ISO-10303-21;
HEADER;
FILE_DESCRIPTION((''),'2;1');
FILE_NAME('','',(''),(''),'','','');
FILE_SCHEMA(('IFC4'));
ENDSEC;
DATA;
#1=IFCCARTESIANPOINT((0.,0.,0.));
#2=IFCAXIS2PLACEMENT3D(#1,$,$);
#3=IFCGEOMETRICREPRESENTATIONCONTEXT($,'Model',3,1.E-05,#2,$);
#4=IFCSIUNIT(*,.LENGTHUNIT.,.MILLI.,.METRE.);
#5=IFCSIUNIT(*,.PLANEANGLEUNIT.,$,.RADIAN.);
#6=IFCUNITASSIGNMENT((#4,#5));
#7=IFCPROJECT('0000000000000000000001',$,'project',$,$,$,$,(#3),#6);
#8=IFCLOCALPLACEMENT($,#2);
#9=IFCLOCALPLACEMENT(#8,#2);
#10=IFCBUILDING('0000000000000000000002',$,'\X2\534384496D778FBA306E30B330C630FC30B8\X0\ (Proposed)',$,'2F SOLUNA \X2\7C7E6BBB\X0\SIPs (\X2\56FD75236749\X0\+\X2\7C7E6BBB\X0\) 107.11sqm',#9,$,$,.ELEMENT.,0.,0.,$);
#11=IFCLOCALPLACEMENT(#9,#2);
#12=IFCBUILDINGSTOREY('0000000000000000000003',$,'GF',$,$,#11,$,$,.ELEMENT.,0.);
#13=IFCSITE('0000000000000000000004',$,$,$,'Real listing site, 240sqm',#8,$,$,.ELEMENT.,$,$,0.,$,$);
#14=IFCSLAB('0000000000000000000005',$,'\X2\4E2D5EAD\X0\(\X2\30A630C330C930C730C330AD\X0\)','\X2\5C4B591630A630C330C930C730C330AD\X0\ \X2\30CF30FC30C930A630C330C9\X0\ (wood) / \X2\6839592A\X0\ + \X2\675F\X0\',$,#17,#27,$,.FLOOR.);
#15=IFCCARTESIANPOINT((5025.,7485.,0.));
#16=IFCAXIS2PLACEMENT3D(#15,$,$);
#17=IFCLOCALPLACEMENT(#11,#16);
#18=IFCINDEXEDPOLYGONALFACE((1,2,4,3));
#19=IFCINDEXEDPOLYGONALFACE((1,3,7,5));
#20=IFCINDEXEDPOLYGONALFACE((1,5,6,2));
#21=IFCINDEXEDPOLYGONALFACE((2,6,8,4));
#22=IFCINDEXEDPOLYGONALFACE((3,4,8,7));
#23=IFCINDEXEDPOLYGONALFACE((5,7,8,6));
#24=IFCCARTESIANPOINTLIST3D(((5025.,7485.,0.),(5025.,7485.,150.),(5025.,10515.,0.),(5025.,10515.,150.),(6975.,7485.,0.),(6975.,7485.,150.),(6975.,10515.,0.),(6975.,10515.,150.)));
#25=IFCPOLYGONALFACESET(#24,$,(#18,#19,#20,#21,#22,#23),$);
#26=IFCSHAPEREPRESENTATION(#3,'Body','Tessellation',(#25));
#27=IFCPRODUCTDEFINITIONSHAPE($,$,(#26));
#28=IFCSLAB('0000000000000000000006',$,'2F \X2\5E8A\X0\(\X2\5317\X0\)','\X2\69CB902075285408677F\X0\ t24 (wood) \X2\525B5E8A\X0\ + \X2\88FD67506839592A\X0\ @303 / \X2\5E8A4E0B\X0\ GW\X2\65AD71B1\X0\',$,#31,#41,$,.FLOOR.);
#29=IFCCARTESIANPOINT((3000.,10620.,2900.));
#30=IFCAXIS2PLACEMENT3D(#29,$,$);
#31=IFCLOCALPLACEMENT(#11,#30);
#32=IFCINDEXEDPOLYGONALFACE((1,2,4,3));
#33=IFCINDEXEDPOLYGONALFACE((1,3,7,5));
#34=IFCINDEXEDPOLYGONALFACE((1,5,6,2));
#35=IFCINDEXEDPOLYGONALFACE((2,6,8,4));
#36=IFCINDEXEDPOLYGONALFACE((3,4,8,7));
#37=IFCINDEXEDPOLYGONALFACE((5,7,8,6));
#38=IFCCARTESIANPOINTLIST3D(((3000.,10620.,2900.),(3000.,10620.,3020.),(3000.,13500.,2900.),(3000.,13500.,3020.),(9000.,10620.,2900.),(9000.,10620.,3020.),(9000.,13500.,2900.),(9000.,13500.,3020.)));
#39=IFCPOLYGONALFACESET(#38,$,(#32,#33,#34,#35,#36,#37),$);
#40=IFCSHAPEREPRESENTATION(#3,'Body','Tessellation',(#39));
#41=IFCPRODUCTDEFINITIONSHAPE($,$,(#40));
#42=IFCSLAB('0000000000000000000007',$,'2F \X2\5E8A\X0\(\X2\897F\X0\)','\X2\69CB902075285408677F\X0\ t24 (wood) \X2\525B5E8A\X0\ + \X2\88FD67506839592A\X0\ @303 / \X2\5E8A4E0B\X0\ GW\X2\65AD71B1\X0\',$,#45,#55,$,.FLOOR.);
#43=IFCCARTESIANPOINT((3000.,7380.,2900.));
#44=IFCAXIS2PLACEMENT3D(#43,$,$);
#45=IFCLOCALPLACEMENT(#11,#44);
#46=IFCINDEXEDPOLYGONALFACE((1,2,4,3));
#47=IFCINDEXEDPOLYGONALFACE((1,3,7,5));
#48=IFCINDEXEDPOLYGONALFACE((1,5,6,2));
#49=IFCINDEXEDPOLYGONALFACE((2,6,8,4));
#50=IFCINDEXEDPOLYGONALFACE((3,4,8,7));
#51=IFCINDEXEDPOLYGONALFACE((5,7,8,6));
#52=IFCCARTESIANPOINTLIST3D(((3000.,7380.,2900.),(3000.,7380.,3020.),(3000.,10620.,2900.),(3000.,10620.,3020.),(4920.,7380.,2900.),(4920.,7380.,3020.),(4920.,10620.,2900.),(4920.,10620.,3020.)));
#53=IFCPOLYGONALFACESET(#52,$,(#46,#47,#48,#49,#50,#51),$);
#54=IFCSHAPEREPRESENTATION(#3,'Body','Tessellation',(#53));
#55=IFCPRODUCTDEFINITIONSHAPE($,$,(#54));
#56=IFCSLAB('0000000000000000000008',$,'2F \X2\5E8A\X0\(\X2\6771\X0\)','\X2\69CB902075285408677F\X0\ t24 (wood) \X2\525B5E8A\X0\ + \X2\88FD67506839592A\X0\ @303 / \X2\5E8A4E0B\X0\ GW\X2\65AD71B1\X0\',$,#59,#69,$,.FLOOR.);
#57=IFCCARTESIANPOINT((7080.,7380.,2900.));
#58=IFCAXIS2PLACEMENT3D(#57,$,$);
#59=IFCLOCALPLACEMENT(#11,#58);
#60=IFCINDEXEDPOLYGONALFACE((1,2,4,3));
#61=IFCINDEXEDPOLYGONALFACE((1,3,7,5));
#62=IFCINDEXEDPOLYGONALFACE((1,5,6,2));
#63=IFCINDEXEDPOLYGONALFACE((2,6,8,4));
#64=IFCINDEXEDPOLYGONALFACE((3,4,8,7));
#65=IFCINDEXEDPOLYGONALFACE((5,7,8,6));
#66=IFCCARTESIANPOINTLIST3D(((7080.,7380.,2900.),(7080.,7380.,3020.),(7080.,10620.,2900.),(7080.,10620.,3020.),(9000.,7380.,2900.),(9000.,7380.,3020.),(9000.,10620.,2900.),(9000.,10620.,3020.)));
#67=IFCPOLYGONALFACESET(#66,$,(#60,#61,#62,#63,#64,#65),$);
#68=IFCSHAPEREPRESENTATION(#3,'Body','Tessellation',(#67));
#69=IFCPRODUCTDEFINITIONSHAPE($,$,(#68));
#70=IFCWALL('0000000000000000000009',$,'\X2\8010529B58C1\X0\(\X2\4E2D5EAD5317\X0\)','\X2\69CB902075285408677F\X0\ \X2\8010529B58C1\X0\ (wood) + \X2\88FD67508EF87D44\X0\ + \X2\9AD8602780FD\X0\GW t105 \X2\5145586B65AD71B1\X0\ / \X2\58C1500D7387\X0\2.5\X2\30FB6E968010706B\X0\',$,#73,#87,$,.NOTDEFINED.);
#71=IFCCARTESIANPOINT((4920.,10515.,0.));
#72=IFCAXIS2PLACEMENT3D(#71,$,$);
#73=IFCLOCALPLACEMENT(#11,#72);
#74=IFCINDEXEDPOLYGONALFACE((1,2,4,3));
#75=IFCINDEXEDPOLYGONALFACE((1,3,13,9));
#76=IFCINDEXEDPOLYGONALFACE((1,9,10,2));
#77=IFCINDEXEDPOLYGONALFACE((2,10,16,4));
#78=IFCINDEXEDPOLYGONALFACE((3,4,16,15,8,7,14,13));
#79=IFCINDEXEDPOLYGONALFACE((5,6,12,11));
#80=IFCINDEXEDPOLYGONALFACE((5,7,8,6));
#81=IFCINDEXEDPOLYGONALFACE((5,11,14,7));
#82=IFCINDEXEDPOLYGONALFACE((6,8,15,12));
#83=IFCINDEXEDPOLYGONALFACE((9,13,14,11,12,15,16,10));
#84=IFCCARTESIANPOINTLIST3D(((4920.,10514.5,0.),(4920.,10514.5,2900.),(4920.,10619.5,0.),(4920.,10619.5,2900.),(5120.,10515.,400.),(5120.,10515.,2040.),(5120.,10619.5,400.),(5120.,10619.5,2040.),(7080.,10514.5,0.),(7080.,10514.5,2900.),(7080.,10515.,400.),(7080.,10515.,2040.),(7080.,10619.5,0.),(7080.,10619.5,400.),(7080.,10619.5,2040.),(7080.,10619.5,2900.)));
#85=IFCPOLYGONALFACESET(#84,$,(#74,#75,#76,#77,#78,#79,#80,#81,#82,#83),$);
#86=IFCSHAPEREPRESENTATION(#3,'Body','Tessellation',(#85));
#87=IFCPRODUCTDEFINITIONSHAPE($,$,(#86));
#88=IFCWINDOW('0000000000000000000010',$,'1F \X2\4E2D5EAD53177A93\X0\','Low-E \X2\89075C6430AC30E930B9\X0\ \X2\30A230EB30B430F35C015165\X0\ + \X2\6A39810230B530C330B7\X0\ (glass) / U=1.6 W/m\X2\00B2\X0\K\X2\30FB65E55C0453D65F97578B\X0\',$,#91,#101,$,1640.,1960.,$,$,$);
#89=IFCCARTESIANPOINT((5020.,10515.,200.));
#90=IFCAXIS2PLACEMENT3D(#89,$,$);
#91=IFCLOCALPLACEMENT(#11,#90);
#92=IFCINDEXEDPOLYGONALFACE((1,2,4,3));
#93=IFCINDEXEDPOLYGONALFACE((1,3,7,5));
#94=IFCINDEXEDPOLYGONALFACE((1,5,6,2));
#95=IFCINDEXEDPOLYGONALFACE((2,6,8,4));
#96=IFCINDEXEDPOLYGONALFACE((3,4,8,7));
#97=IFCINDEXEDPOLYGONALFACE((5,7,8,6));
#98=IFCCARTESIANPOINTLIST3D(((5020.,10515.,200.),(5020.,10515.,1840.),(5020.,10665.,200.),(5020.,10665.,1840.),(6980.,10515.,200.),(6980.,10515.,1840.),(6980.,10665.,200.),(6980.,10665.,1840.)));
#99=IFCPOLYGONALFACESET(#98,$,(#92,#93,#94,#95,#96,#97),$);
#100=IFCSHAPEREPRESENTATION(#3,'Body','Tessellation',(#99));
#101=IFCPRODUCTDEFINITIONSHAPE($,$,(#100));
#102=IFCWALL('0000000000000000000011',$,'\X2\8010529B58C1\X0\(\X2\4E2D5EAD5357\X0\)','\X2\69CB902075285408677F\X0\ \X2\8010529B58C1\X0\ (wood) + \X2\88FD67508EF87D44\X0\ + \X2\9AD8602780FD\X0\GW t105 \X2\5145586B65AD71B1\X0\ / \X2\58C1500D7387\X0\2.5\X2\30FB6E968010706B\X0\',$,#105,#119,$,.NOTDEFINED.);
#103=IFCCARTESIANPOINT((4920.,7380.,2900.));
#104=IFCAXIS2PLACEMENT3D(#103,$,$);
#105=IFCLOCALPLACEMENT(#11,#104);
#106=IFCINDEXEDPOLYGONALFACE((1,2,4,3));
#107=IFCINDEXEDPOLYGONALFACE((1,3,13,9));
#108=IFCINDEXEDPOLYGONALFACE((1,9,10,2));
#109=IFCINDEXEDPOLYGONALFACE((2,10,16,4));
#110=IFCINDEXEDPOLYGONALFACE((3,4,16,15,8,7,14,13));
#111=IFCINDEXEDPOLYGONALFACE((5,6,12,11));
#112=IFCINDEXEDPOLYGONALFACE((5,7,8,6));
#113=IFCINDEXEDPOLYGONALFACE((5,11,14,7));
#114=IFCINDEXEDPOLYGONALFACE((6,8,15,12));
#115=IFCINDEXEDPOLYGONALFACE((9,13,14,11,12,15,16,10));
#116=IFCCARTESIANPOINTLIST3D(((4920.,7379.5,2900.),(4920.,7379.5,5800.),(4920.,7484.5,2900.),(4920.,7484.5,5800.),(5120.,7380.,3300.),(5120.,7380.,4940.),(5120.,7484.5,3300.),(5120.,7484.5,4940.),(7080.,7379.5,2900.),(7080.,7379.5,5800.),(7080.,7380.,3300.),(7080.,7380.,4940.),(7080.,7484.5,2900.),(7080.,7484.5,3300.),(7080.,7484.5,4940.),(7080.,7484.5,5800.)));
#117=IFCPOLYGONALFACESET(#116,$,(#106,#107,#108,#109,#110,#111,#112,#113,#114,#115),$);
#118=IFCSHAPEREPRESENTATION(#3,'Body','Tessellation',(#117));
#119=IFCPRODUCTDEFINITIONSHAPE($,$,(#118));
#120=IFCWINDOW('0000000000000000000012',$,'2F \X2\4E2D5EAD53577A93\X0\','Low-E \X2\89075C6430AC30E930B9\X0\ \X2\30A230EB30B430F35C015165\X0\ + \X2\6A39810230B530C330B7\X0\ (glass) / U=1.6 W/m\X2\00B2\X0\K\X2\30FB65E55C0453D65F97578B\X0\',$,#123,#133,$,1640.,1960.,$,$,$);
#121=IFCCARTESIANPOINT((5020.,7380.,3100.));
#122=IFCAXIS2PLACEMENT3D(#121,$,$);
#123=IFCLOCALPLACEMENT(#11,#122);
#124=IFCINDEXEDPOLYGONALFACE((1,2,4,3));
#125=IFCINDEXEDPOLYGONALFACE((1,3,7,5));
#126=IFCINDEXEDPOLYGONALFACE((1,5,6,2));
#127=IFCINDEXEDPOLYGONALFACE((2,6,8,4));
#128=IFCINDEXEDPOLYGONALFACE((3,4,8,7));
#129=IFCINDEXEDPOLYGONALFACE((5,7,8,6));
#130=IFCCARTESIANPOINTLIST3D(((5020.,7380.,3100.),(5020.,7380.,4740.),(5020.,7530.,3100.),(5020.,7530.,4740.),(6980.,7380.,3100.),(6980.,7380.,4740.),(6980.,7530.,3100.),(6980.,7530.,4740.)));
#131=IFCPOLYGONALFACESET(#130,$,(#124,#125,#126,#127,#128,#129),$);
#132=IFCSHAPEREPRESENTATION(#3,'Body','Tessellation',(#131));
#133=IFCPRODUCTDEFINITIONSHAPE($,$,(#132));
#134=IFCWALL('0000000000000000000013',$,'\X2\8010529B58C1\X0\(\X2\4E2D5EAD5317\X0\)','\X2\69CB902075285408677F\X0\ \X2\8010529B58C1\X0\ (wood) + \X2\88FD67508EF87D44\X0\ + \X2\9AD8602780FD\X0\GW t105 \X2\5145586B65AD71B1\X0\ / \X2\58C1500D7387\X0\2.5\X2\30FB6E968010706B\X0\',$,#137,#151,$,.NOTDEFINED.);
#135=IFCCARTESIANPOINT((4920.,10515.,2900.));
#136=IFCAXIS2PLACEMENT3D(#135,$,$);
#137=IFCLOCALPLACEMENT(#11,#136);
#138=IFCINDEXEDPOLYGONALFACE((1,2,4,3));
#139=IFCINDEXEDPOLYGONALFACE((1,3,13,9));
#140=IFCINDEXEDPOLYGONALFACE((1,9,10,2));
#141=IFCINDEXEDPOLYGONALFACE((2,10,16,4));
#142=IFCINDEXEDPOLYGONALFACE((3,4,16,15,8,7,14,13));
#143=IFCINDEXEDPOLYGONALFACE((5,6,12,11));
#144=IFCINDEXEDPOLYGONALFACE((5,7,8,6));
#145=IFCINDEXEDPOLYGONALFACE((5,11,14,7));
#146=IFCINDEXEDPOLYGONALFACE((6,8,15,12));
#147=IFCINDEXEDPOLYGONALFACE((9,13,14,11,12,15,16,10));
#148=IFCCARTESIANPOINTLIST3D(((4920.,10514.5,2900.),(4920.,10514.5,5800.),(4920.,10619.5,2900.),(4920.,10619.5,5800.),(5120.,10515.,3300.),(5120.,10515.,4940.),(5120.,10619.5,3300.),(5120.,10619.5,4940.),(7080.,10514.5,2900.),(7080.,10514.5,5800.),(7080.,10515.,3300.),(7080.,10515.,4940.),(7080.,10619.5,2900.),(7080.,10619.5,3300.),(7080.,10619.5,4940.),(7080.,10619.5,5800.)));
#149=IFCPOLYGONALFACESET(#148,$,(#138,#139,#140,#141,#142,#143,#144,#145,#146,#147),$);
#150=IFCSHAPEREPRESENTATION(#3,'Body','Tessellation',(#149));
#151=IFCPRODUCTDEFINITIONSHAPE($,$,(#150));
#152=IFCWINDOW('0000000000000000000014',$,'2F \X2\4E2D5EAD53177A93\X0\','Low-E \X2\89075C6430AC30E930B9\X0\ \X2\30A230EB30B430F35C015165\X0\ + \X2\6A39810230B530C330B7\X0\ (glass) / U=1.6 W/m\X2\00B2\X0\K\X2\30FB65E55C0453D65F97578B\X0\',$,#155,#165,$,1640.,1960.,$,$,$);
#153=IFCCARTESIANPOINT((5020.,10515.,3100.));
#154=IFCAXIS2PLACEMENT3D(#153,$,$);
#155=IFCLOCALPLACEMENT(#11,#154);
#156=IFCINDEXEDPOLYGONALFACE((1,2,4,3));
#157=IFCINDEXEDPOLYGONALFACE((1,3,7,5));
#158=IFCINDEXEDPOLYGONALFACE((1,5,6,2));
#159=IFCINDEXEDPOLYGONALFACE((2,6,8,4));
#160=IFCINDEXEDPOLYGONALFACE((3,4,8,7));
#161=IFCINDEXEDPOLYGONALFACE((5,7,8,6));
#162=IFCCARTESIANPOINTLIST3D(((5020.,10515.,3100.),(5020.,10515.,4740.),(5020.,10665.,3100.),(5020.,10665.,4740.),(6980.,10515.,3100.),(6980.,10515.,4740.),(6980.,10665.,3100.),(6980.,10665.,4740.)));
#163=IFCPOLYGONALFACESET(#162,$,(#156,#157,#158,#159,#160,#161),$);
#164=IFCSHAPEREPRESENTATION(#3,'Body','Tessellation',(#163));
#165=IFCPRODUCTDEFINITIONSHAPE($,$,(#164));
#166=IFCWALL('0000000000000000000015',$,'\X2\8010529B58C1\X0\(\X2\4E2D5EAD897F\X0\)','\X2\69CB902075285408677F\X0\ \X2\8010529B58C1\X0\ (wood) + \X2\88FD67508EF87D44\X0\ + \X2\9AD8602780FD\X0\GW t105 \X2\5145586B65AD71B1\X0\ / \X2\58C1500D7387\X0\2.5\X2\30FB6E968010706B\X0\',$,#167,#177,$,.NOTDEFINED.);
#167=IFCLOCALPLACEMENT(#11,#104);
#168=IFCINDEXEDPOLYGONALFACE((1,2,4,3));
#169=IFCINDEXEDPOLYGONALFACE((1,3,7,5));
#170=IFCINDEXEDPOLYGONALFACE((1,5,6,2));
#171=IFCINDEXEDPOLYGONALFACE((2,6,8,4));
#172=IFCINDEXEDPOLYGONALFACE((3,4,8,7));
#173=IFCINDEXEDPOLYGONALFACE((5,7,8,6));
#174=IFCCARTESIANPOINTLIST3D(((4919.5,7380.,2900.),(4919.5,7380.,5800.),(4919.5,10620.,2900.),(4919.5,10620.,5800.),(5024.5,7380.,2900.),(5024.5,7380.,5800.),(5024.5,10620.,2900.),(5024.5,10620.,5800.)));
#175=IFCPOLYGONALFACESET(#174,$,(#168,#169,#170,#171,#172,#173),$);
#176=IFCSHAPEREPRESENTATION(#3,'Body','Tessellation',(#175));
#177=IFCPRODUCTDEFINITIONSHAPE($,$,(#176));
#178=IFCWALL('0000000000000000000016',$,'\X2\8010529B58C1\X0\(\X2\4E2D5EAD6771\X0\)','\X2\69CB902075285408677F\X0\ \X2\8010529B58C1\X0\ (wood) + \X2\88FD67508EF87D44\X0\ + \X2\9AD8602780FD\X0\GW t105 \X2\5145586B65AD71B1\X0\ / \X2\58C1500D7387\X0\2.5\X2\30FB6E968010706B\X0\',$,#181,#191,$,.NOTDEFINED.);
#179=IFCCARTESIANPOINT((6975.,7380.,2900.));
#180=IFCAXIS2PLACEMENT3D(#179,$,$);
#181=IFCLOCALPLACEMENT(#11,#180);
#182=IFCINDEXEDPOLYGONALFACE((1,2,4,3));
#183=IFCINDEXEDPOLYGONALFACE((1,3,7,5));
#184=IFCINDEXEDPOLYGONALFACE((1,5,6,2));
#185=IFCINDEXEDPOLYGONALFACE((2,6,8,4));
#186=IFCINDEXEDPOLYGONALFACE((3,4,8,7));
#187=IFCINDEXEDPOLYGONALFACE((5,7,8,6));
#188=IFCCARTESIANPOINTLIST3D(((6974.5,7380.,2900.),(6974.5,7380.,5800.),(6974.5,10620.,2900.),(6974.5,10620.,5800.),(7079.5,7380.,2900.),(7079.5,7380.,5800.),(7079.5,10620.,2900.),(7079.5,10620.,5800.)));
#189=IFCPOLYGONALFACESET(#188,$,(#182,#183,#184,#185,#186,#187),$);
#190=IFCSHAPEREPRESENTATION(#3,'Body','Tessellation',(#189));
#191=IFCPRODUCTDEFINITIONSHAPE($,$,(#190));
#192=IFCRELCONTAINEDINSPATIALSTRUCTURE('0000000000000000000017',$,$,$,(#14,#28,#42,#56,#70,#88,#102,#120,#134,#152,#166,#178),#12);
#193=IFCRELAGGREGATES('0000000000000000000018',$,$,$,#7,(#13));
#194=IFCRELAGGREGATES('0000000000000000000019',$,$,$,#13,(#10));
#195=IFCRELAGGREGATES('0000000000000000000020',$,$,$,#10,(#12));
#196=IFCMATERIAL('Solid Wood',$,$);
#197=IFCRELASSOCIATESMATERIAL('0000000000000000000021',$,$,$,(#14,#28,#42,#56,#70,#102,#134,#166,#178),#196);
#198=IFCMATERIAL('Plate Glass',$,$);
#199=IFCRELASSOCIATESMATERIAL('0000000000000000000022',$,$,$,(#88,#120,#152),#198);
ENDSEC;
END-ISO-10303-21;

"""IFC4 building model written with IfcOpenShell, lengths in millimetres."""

from ifc_helpers import new_model, si_unit, frame, frame_2d, origin, place, context, project, spatial, rectangle, extrude, material, element, fill, save


model = new_model("IFC4")

# Units and contexts
model_context = context("Model", 3, precision=1e-05, world=origin())
ifc_project = project(units=[si_unit("LENGTHUNIT", "METRE", prefix="MILLI"), si_unit("PLANEANGLEUNIT", "RADIAN")], contexts=[model_context])

# Site, building, storey
site_placement = place(None, origin())
site = spatial("IfcSite", under=ifc_project, at=site_placement, ObjectType="Real listing site, 240sqm", CompositionType="ELEMENT", RefElevation=0.0)
building_placement = place(site_placement, origin())
building = spatial("IfcBuilding", under=site, at=building_placement, Name="千葉海辺のコテージ (Proposed)", ObjectType="2F SOLUNA 籾殻SIPs (国産杉+籾殻) 107.11sqm", CompositionType="ELEMENT", ElevationOfRefHeight=0.0, ElevationOfTerrain=0.0)
storey_placement = place(building_placement, origin())
storey = spatial("IfcBuildingStorey", under=building, at=storey_placement, Name="GF", CompositionType="ELEMENT", Elevation=0.0)

# Slabs
ifc_material_1 = material(Name="Solid Wood")
slab_1_placement = place(storey_placement, frame((5025.0, 7485.0, 0.0)))
element("IfcSlab", 1, at=slab_1_placement, inside=storey, material=ifc_material_1, Name="中庭(ウッドデッキ)", Description="屋外ウッドデッキ ハードウッド (wood) / 根太 + 束", PredefinedType="FLOOR", context=model_context, shape_type="SweptSolid", body=[
    extrude(rectangle(XDim=1950.0, YDim=3030.0, at=frame_2d((975.0, 1515.0))), frame((5025.0, 7485.0, 0.0)), (0.0, 0.0, 1.0), 150.0),
])
slab_2_placement = place(storey_placement, frame((3000.0, 10620.0, 2900.0)))
element("IfcSlab", 2, at=slab_2_placement, inside=storey, material=ifc_material_1, Name="2F 床(北)", Description="構造用合板 t24 (wood) 剛床 + 製材根太 @303 / 床下 GW断熱", PredefinedType="FLOOR", context=model_context, shape_type="SweptSolid", body=[
    extrude(rectangle(XDim=6000.0, YDim=2880.0, at=frame_2d((3000.0, 1440.0))), frame((3000.0, 10620.0, 2900.0)), (0.0, 0.0, 1.0), 120.0),
])
slab_3_placement = place(storey_placement, frame((3000.0, 7380.0, 2900.0)))
element("IfcSlab", 3, at=slab_3_placement, inside=storey, material=ifc_material_1, Name="2F 床(西)", Description="構造用合板 t24 (wood) 剛床 + 製材根太 @303 / 床下 GW断熱", PredefinedType="FLOOR", context=model_context, shape_type="SweptSolid", body=[
    extrude(rectangle(XDim=1920.0, YDim=3240.0, at=frame_2d((960.0, 1620.0))), frame((3000.0, 7380.0, 2900.0)), (0.0, 0.0, 1.0), 120.0),
])
slab_4_placement = place(storey_placement, frame((7080.0, 7380.0, 2900.0)))
element("IfcSlab", 4, at=slab_4_placement, inside=storey, material=ifc_material_1, Name="2F 床(東)", Description="構造用合板 t24 (wood) 剛床 + 製材根太 @303 / 床下 GW断熱", PredefinedType="FLOOR", context=model_context, shape_type="SweptSolid", body=[
    extrude(rectangle(XDim=1920.0, YDim=3240.0, at=frame_2d((960.0, 1620.0))), frame((7080.0, 7380.0, 2900.0)), (0.0, 0.0, 1.0), 120.0),
])

# Wall, opening, window
wall_1_placement = place(storey_placement, frame((4920.0, 10515.0, 0.0)))
wall_1 = element("IfcWall", 5, at=wall_1_placement, inside=storey, material=ifc_material_1, Name="耐力壁(中庭北)", Description="構造用合板 耐力壁 (wood) + 製材軸組 + 高性能GW t105 充填断熱 / 壁倍率2.5・準耐火", PredefinedType="NOTDEFINED", context=model_context, shape_type="SweptSolid", body=[
    extrude(rectangle(XDim=2160.0, YDim=105.0, at=frame_2d((1080.0, 52.0))), frame((4920.0, 10515.0, 0.0)), (0.0, 0.0, 1.0), 2900.0),
])
opening_1_placement = place(storey_placement, frame((5020.0, 10515.0, 200.0)))
opening_1 = element("IfcOpeningElement", 6, at=opening_1_placement, cuts=wall_1, PredefinedType="NOTDEFINED", context=model_context, shape_type="SweptSolid", body=[
    extrude(rectangle(XDim=1960.0, YDim=150.0, at=frame_2d((980.0, 75.0))), frame((5020.0, 10515.0, 200.0)), (0.0, 0.0, 1.0), 1640.0),
])
ifc_material_2 = material(Name="Plate Glass")
window_1_placement = place(storey_placement, frame((5020.0, 10515.0, 200.0)))
window_1 = element("IfcWindow", 7, at=window_1_placement, inside=storey, material=ifc_material_2, Name="1F 中庭北窓", Description="Low-E 複層ガラス アルゴン封入 + 樹脂サッシ (glass) / U=1.6 W/m²K・日射取得型", OverallHeight=1640.0, OverallWidth=1960.0, context=model_context, shape_type="SweptSolid", body=[
    extrude(rectangle(XDim=1960.0, YDim=150.0, at=frame_2d((980.0, 75.0))), frame((5020.0, 10515.0, 200.0)), (0.0, 0.0, 1.0), 1640.0),
])
fill(opening_1, window_1)

# Walls, openings, windows
wall_2_placement = place(storey_placement, frame((4920.0, 7380.0, 2900.0)))
wall_2 = element("IfcWall", 8, at=wall_2_placement, inside=storey, material=ifc_material_1, Name="耐力壁(中庭南)", Description="構造用合板 耐力壁 (wood) + 製材軸組 + 高性能GW t105 充填断熱 / 壁倍率2.5・準耐火", PredefinedType="NOTDEFINED", context=model_context, shape_type="SweptSolid", body=[
    extrude(rectangle(XDim=2160.0, YDim=105.0, at=frame_2d((1080.0, 52.0))), frame((4920.0, 7380.0, 2900.0)), (0.0, 0.0, 1.0), 2900.0),
])
opening_2_placement = place(storey_placement, frame((5020.0, 7380.0, 3100.0)))
opening_2 = element("IfcOpeningElement", 9, at=opening_2_placement, cuts=wall_2, PredefinedType="NOTDEFINED", context=model_context, shape_type="SweptSolid", body=[
    extrude(rectangle(XDim=1960.0, YDim=150.0, at=frame_2d((980.0, 75.0))), frame((5020.0, 7380.0, 3100.0)), (0.0, 0.0, 1.0), 1640.0),
])
window_2_placement = place(storey_placement, frame((5020.0, 7380.0, 3100.0)))
window_2 = element("IfcWindow", 10, at=window_2_placement, inside=storey, material=ifc_material_2, Name="2F 中庭南窓", Description="Low-E 複層ガラス アルゴン封入 + 樹脂サッシ (glass) / U=1.6 W/m²K・日射取得型", OverallHeight=1640.0, OverallWidth=1960.0, context=model_context, shape_type="SweptSolid", body=[
    extrude(rectangle(XDim=1960.0, YDim=150.0, at=frame_2d((980.0, 75.0))), frame((5020.0, 7380.0, 3100.0)), (0.0, 0.0, 1.0), 1640.0),
])
fill(opening_2, window_2)
wall_3_placement = place(storey_placement, frame((4920.0, 10515.0, 2900.0)))
wall_3 = element("IfcWall", 11, at=wall_3_placement, inside=storey, material=ifc_material_1, Name="耐力壁(中庭北)", Description="構造用合板 耐力壁 (wood) + 製材軸組 + 高性能GW t105 充填断熱 / 壁倍率2.5・準耐火", PredefinedType="NOTDEFINED", context=model_context, shape_type="SweptSolid", body=[
    extrude(rectangle(XDim=2160.0, YDim=105.0, at=frame_2d((1080.0, 52.0))), frame((4920.0, 10515.0, 2900.0)), (0.0, 0.0, 1.0), 2900.0),
])
opening_3_placement = place(storey_placement, frame((5020.0, 10515.0, 3100.0)))
opening_3 = element("IfcOpeningElement", 12, at=opening_3_placement, cuts=wall_3, PredefinedType="NOTDEFINED", context=model_context, shape_type="SweptSolid", body=[
    extrude(rectangle(XDim=1960.0, YDim=150.0, at=frame_2d((980.0, 75.0))), frame((5020.0, 10515.0, 3100.0)), (0.0, 0.0, 1.0), 1640.0),
])
window_3_placement = place(storey_placement, frame((5020.0, 10515.0, 3100.0)))
window_3 = element("IfcWindow", 13, at=window_3_placement, inside=storey, material=ifc_material_2, Name="2F 中庭北窓", Description="Low-E 複層ガラス アルゴン封入 + 樹脂サッシ (glass) / U=1.6 W/m²K・日射取得型", OverallHeight=1640.0, OverallWidth=1960.0, context=model_context, shape_type="SweptSolid", body=[
    extrude(rectangle(XDim=1960.0, YDim=150.0, at=frame_2d((980.0, 75.0))), frame((5020.0, 10515.0, 3100.0)), (0.0, 0.0, 1.0), 1640.0),
])
fill(opening_3, window_3)

# Walls
wall_4_placement = place(storey_placement, frame((4920.0, 7380.0, 2900.0)))
element("IfcWall", 14, at=wall_4_placement, inside=storey, material=ifc_material_1, Name="耐力壁(中庭西)", Description="構造用合板 耐力壁 (wood) + 製材軸組 + 高性能GW t105 充填断熱 / 壁倍率2.5・準耐火", PredefinedType="NOTDEFINED", context=model_context, shape_type="SweptSolid", body=[
    extrude(rectangle(XDim=105.0, YDim=3240.0, at=frame_2d((52.0, 1620.0))), frame((4920.0, 7380.0, 2900.0)), (0.0, 0.0, 1.0), 2900.0),
])
wall_5_placement = place(storey_placement, frame((6975.0, 7380.0, 2900.0)))
element("IfcWall", 15, at=wall_5_placement, inside=storey, material=ifc_material_1, Name="耐力壁(中庭東)", Description="構造用合板 耐力壁 (wood) + 製材軸組 + 高性能GW t105 充填断熱 / 壁倍率2.5・準耐火", PredefinedType="NOTDEFINED", context=model_context, shape_type="SweptSolid", body=[
    extrude(rectangle(XDim=105.0, YDim=3240.0, at=frame_2d((52.0, 1620.0))), frame((6975.0, 7380.0, 2900.0)), (0.0, 0.0, 1.0), 2900.0),
])

save(model, "model.ifc")
